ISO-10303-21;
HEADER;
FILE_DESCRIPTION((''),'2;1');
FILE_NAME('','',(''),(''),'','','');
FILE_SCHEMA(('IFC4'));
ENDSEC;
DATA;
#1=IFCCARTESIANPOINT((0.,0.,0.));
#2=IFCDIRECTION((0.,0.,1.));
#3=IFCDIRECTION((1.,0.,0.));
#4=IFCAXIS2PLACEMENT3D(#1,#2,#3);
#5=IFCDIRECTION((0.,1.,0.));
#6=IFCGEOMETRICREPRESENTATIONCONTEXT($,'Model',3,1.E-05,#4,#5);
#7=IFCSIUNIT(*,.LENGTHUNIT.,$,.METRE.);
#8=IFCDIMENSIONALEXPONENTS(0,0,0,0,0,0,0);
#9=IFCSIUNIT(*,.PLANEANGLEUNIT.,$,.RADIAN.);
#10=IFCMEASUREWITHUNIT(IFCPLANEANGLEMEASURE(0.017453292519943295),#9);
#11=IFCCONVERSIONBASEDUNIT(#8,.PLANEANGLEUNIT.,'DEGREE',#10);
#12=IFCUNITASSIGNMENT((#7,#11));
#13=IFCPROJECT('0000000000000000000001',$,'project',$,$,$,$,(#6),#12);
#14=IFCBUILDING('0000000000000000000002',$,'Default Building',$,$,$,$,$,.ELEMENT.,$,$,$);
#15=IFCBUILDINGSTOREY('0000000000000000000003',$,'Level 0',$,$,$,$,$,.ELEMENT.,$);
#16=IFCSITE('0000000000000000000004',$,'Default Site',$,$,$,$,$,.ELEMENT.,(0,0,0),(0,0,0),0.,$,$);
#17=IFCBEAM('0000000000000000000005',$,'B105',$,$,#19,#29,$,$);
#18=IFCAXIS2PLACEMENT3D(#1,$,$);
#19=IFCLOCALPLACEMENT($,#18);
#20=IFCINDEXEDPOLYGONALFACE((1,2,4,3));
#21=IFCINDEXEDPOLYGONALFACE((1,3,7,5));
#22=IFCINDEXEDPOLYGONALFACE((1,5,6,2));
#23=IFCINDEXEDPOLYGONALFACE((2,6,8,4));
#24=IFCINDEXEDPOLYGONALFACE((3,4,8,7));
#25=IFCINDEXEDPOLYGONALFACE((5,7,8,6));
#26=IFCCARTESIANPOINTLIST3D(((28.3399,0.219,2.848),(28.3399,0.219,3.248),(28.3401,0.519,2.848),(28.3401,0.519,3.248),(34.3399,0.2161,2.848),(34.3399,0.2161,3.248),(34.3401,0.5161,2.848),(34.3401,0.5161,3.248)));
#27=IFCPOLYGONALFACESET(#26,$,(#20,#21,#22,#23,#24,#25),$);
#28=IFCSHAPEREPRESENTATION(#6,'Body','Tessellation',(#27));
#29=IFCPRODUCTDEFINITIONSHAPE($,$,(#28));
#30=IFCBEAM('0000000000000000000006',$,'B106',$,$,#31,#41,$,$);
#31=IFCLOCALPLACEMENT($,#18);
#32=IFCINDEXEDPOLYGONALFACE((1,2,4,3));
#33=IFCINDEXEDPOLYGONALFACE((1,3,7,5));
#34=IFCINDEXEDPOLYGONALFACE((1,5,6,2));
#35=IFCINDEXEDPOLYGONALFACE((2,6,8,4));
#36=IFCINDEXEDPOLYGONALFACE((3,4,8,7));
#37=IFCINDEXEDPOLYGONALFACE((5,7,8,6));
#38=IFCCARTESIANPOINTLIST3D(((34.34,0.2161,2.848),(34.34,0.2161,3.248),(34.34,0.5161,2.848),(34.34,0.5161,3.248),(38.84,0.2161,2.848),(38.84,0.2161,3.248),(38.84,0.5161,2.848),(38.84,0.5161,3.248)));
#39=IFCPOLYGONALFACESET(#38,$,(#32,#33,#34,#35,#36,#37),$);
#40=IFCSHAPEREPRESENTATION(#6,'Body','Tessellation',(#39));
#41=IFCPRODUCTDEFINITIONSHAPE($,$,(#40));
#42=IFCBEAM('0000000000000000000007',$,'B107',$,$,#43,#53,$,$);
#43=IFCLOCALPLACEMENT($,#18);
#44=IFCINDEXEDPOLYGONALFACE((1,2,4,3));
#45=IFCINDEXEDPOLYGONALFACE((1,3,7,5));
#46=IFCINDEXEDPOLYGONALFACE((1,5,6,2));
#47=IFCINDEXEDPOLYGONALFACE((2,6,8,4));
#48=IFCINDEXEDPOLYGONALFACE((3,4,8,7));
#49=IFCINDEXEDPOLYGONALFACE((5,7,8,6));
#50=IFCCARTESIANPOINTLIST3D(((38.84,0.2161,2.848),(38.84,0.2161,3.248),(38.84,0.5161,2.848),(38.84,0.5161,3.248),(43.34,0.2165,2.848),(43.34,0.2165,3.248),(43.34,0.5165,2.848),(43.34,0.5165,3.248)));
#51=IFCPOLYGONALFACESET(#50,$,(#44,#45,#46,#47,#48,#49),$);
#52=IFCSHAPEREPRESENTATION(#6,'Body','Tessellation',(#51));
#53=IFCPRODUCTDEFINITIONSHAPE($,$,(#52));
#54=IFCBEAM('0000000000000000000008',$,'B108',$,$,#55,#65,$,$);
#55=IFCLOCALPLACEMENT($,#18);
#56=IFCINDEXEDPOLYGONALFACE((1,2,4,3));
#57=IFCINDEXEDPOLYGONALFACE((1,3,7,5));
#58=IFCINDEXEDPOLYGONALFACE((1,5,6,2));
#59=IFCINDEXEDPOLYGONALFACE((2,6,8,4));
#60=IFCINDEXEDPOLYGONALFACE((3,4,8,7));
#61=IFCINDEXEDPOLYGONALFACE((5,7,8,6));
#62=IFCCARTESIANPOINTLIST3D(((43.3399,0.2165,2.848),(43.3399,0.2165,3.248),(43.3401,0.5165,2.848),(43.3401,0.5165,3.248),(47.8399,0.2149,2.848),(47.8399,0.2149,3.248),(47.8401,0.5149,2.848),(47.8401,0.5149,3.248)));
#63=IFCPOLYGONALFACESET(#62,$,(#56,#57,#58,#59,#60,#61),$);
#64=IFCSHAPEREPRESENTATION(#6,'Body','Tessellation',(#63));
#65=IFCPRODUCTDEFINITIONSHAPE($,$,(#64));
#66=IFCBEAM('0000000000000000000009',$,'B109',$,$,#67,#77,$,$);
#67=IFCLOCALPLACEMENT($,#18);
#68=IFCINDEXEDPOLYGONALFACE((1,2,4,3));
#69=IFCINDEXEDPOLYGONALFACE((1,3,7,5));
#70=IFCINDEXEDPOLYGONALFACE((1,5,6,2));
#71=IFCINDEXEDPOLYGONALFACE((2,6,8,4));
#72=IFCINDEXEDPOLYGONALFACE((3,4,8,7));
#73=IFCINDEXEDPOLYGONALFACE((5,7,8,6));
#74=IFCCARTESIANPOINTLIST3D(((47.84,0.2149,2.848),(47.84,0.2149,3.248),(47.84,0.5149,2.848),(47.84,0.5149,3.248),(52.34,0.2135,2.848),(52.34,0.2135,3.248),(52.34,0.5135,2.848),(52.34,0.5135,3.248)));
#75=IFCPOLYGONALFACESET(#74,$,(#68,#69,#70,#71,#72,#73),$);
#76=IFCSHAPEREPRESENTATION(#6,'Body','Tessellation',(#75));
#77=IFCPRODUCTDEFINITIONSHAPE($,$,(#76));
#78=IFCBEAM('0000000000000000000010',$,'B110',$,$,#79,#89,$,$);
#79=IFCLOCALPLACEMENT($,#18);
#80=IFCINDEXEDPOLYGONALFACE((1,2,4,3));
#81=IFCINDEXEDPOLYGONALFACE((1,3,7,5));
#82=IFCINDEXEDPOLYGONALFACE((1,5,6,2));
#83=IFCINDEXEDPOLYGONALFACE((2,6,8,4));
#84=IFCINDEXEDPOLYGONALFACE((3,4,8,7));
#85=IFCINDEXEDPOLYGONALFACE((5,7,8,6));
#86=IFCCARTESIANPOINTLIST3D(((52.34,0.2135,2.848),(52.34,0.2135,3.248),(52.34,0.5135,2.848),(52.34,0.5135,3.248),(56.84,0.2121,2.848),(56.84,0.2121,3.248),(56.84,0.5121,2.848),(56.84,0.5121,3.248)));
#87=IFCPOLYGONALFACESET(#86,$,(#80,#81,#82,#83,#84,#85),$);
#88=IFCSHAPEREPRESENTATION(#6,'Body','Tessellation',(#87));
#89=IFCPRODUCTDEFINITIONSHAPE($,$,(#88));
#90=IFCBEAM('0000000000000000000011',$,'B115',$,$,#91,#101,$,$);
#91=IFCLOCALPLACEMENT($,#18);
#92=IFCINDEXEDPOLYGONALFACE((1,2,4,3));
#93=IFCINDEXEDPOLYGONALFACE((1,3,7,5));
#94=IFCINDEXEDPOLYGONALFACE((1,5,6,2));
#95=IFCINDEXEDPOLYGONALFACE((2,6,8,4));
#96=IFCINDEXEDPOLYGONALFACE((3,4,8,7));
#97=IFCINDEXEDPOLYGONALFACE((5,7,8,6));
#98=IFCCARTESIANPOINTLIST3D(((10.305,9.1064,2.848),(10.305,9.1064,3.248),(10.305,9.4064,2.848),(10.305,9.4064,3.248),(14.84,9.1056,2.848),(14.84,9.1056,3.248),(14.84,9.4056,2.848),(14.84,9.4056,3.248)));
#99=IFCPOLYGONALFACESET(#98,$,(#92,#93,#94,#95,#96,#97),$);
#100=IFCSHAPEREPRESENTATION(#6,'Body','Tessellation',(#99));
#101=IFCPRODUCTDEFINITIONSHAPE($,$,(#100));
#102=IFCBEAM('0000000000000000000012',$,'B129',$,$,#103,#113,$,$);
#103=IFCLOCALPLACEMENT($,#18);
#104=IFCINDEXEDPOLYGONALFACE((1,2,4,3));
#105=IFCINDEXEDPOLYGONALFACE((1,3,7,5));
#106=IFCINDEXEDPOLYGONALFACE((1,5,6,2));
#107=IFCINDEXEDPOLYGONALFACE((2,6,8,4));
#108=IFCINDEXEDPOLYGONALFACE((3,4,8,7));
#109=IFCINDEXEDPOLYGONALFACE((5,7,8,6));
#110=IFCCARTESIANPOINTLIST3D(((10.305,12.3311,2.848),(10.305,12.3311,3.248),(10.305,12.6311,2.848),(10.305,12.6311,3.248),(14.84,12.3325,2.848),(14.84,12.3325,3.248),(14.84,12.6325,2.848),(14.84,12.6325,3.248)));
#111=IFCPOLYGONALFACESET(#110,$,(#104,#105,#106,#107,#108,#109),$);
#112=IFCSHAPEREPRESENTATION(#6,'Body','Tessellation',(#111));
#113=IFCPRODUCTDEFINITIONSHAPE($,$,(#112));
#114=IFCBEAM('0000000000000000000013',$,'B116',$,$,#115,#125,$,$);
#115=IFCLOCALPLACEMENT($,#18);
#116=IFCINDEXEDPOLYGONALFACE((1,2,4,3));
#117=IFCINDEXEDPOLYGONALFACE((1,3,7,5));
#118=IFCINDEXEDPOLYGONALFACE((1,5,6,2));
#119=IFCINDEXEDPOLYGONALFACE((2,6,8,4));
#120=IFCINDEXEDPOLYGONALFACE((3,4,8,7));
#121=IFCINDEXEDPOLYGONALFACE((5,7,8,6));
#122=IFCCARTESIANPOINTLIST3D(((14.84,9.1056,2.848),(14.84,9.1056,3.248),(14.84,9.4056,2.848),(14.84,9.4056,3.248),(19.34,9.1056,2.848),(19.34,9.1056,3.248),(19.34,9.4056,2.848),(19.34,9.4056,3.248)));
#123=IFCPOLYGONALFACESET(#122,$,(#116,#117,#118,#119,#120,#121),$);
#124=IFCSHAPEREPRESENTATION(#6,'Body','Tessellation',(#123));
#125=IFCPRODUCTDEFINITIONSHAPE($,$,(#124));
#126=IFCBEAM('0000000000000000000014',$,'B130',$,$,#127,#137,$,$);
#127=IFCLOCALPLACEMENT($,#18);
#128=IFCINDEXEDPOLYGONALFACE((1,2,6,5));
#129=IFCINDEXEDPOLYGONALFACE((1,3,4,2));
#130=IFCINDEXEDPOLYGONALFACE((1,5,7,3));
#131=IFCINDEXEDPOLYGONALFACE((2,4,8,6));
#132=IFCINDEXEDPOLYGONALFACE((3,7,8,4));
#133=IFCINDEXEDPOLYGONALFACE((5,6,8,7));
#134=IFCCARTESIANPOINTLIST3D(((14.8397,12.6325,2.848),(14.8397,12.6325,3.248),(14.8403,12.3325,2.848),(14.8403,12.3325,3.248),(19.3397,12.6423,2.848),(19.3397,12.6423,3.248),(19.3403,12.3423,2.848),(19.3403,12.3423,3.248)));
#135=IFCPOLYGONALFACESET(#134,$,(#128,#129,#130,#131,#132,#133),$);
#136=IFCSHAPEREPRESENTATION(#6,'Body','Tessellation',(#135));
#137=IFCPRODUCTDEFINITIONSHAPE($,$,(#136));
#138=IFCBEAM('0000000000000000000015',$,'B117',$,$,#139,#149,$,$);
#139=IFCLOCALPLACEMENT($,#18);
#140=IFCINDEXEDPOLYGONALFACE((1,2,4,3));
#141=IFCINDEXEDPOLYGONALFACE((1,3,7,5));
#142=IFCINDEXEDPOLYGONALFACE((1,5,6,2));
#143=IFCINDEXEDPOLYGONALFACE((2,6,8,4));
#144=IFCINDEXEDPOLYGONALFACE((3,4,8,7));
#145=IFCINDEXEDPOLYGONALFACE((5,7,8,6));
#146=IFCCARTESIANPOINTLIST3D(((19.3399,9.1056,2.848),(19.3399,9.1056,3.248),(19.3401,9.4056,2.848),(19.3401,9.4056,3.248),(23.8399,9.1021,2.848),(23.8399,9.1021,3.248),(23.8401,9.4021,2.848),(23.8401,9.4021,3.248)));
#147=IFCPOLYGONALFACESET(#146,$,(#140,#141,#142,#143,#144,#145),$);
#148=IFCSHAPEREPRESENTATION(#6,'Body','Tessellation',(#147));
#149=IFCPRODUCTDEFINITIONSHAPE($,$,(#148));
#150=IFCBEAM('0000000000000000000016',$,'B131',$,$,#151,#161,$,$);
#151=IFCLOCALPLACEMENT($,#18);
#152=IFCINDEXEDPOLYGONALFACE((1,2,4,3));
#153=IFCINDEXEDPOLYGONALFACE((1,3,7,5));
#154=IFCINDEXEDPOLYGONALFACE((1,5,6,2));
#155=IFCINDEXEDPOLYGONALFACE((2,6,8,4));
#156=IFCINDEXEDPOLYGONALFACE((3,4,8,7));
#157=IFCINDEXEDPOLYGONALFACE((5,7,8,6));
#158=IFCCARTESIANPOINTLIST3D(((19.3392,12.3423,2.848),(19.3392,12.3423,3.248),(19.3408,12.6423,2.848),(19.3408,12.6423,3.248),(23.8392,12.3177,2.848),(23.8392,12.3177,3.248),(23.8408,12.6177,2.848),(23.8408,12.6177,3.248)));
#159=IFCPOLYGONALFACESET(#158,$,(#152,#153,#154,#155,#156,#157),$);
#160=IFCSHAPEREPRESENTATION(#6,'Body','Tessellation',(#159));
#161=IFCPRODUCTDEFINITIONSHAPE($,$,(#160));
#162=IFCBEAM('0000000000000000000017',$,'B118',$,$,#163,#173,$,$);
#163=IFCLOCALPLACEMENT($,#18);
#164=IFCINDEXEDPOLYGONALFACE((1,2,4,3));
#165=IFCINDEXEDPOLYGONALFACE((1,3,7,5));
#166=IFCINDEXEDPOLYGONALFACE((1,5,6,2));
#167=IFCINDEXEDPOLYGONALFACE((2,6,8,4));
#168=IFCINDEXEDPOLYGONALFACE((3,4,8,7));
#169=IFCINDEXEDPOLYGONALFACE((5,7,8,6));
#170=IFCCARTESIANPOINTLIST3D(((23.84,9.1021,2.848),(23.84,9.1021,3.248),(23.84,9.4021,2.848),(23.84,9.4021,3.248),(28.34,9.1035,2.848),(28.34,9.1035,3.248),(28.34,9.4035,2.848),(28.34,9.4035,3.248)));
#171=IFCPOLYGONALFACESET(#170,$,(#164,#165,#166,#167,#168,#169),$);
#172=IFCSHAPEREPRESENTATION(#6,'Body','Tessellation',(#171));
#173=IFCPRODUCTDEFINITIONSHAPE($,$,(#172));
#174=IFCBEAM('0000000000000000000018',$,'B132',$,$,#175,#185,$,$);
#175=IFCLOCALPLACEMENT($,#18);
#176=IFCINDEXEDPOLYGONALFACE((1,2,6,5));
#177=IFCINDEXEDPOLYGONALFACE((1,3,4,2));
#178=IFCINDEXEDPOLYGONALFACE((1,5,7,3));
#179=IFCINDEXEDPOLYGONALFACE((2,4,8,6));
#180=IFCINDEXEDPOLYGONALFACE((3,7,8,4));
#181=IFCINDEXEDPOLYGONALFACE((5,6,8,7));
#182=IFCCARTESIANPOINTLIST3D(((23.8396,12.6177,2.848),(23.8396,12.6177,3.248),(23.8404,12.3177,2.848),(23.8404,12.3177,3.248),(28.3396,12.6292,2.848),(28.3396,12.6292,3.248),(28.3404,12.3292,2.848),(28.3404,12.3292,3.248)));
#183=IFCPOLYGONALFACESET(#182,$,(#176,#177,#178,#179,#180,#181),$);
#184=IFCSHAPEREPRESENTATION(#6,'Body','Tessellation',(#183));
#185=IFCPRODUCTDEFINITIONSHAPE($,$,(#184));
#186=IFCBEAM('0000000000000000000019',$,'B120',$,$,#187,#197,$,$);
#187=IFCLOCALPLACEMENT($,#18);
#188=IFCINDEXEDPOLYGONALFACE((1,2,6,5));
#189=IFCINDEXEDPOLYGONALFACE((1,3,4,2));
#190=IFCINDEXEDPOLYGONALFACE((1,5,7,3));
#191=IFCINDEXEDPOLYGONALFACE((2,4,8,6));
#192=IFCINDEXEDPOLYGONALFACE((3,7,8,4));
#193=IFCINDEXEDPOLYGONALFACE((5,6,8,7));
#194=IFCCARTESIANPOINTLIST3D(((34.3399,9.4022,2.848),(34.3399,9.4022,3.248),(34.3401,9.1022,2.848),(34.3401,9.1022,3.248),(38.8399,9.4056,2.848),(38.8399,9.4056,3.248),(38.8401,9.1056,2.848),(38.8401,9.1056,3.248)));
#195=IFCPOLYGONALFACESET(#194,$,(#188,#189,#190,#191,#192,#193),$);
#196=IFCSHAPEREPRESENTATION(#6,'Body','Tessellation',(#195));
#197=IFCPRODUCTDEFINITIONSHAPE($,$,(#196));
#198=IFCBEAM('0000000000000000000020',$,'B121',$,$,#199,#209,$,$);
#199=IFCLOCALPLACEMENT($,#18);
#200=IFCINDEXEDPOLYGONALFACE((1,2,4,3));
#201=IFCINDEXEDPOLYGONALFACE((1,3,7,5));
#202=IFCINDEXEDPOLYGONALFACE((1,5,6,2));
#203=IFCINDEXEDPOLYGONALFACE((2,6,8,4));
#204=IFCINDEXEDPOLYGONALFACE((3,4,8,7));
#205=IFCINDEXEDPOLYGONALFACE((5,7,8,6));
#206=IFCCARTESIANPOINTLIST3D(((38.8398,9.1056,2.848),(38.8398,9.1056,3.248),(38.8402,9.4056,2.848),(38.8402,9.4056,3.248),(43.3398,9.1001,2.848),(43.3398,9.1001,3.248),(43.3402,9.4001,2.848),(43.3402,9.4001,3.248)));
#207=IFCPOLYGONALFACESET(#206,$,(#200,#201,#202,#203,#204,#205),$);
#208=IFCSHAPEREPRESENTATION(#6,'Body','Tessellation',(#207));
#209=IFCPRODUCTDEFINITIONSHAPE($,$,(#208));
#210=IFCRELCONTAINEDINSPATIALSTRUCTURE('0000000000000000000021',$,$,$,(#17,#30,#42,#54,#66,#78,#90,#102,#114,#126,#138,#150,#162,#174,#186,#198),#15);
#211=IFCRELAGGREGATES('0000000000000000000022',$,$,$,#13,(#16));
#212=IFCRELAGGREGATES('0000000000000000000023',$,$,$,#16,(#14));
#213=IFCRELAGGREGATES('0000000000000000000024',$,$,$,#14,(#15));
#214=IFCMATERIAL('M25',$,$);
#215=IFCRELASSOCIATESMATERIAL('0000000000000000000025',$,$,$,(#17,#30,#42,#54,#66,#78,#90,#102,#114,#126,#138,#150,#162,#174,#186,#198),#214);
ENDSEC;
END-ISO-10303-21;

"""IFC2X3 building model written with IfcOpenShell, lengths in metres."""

from ifc_helpers import new_model, entity, si_unit, converted_unit, direction, frame, frame_2d, origin_with_axes, place, context, project, spatial, rectangle, extrude, material, element, save


model = new_model("IFC2X3")

# Units and contexts
model_context = context("Model", 3, precision=1e-05, world=origin_with_axes(), true_north=direction((0.0, 1.0, 0.0)))
ifc_project = project(units=[si_unit("LENGTHUNIT", "METRE"), converted_unit("PLANEANGLEUNIT", "DEGREE", entity("IfcPlaneAngleMeasure", 0.017453292519943295), si_unit("PLANEANGLEUNIT", "RADIAN"), dimensions=[0, 0, 0, 0, 0, 0, 0])], contexts=[model_context])

# Site, building, storey
site = spatial("IfcSite", under=ifc_project, Name="Default Site", CompositionType="ELEMENT", RefLatitude=(0, 0, 0), RefLongitude=(0, 0, 0), RefElevation=0.0)
building = spatial("IfcBuilding", under=site, Name="Default Building", CompositionType="ELEMENT")
storey = spatial("IfcBuildingStorey", under=building, Name="Level 0", CompositionType="ELEMENT")

# Beams
ifc_material = material(Name="M25")
placement = place(None, origin_with_axes())
element("IfcBeam", 1, at=placement, inside=storey, material=ifc_material, Name="B105", context=model_context, shape_type="SweptSolid", body=[
    extrude(rectangle(XDim=0.3, YDim=0.4, at=frame_2d((0.0, 0.0), x_axis=(0.0, 1.0, 0.0))), frame((28.34, 0.369, 3.048), z_axis=(1.0, -0.000487, 0.0), x_axis=(0.0, 0.0, -1.0)), (0.0, 0.0, 1.0), 6.0),
])
element("IfcBeam", 2, at=placement, inside=storey, material=ifc_material, Name="B106", context=model_context, shape_type="SweptSolid", body=[
    extrude(rectangle(XDim=0.3, YDim=0.4, at=frame_2d((0.0, 0.0), x_axis=(0.0, 1.0, 0.0))), frame((34.34, 0.3661, 3.048), z_axis=(1.0, 0.000003, 0.0), x_axis=(0.0, 0.0, -1.0)), (0.0, 0.0, 1.0), 4.5),
])
element("IfcBeam", 3, at=placement, inside=storey, material=ifc_material, Name="B107", context=model_context, shape_type="SweptSolid", body=[
    extrude(rectangle(XDim=0.3, YDim=0.4, at=frame_2d((0.0, 0.0), x_axis=(0.0, 1.0, 0.0))), frame((38.84, 0.3661, 3.048), z_axis=(1.0, 0.000077, 0.0), x_axis=(0.0, 0.0, -1.0)), (0.0, 0.0, 1.0), 4.5),
])
element("IfcBeam", 4, at=placement, inside=storey, material=ifc_material, Name="B108", context=model_context, shape_type="SweptSolid", body=[
    extrude(rectangle(XDim=0.3, YDim=0.4, at=frame_2d((0.0, 0.0), x_axis=(0.0, 1.0, 0.0))), frame((43.34, 0.3665, 3.048), z_axis=(1.0, -0.000358, 0.0), x_axis=(0.0, 0.0, -1.0)), (0.0, 0.0, 1.0), 4.5),
])
element("IfcBeam", 5, at=placement, inside=storey, material=ifc_material, Name="B109", context=model_context, shape_type="SweptSolid", body=[
    extrude(rectangle(XDim=0.3, YDim=0.4, at=frame_2d((0.0, 0.0), x_axis=(0.0, 1.0, 0.0))), frame((47.84, 0.3649, 3.048), z_axis=(1.0, -0.000297, 0.0), x_axis=(0.0, 0.0, -1.0)), (0.0, 0.0, 1.0), 4.5),
])
element("IfcBeam", 6, at=placement, inside=storey, material=ifc_material, Name="B110", context=model_context, shape_type="SweptSolid", body=[
    extrude(rectangle(XDim=0.3, YDim=0.4, at=frame_2d((0.0, 0.0), x_axis=(0.0, 1.0, 0.0))), frame((52.34, 0.3635, 3.048), z_axis=(1.0, -0.000311, 0.0), x_axis=(0.0, 0.0, -1.0)), (0.0, 0.0, 1.0), 4.5),
])
element("IfcBeam", 7, at=placement, inside=storey, material=ifc_material, Name="B115", context=model_context, shape_type="SweptSolid", body=[
    extrude(rectangle(XDim=0.3, YDim=0.4, at=frame_2d((0.0, 0.0), x_axis=(0.0, 1.0, 0.0))), frame((10.305, 9.2564, 3.048), z_axis=(1.0, -0.000182, 0.0), x_axis=(0.0, 0.0, -1.0)), (0.0, 0.0, 1.0), 4.535),
])
element("IfcBeam", 8, at=placement, inside=storey, material=ifc_material, Name="B129", context=model_context, shape_type="SweptSolid", body=[
    extrude(rectangle(XDim=0.3, YDim=0.4, at=frame_2d((0.0, 0.0), x_axis=(0.0, 1.0, 0.0))), frame((10.305, 12.4811, 3.048), z_axis=(1.0, 0.000301, 0.0), x_axis=(0.0, 0.0, -1.0)), (0.0, 0.0, 1.0), 4.535),
])
element("IfcBeam", 9, at=placement, inside=storey, material=ifc_material, Name="B116", context=model_context, shape_type="SweptSolid", body=[
    extrude(rectangle(XDim=0.3, YDim=0.4, at=frame_2d((0.0, 0.0), x_axis=(0.0, 1.0, 0.0))), frame((14.84, 9.2556, 3.048), z_axis=(1.0, 0.000013, 0.0), x_axis=(0.0, 0.0, -1.0)), (0.0, 0.0, 1.0), 4.5),
])
element("IfcBeam", 10, at=placement, inside=storey, material=ifc_material, Name="B130", context=model_context, shape_type="SweptSolid", body=[
    extrude(rectangle(XDim=0.3, YDim=0.4, at=frame_2d((0.0, 0.0), x_axis=(0.0, 1.0, 0.0))), frame((14.84, 12.4825, 3.048), z_axis=(0.999998, 0.002176, 0.0), x_axis=(0.0, 0.0, -1.0)), (0.0, 0.0, 1.0), 4.5),
])
element("IfcBeam", 11, at=placement, inside=storey, material=ifc_material, Name="B117", context=model_context, shape_type="SweptSolid", body=[
    extrude(rectangle(XDim=0.3, YDim=0.4, at=frame_2d((0.0, 0.0), x_axis=(0.0, 1.0, 0.0))), frame((19.34, 9.2556, 3.048), z_axis=(1.0, -0.000779, 0.0), x_axis=(0.0, 0.0, -1.0)), (0.0, 0.0, 1.0), 4.5),
])
element("IfcBeam", 12, at=placement, inside=storey, material=ifc_material, Name="B131", context=model_context, shape_type="SweptSolid", body=[
    extrude(rectangle(XDim=0.3, YDim=0.4, at=frame_2d((0.0, 0.0), x_axis=(0.0, 1.0, 0.0))), frame((19.34, 12.4923, 3.048), z_axis=(0.999985, -0.005463, 0.0), x_axis=(0.0, 0.0, -1.0)), (0.0, 0.0, 1.0), 4.5001),
])
element("IfcBeam", 13, at=placement, inside=storey, material=ifc_material, Name="B118", context=model_context, shape_type="SweptSolid", body=[
    extrude(rectangle(XDim=0.3, YDim=0.4, at=frame_2d((0.0, 0.0), x_axis=(0.0, 1.0, 0.0))), frame((23.84, 9.2521, 3.048), z_axis=(1.0, 0.000307, 0.0), x_axis=(0.0, 0.0, -1.0)), (0.0, 0.0, 1.0), 4.5),
])
element("IfcBeam", 14, at=placement, inside=storey, material=ifc_material, Name="B132", context=model_context, shape_type="SweptSolid", body=[
    extrude(rectangle(XDim=0.3, YDim=0.4, at=frame_2d((0.0, 0.0), x_axis=(0.0, 1.0, 0.0))), frame((23.84, 12.4677, 3.048), z_axis=(0.999997, 0.002551, 0.0), x_axis=(0.0, 0.0, -1.0)), (0.0, 0.0, 1.0), 4.5),
])
element("IfcBeam", 15, at=placement, inside=storey, material=ifc_material, Name="B120", context=model_context, shape_type="SweptSolid", body=[
    extrude(rectangle(XDim=0.3, YDim=0.4, at=frame_2d((0.0, 0.0), x_axis=(0.0, 1.0, 0.0))), frame((34.34, 9.2522, 3.048), z_axis=(1.0, 0.000748, 0.0), x_axis=(0.0, 0.0, -1.0)), (0.0, 0.0, 1.0), 4.5),
])
element("IfcBeam", 16, at=placement, inside=storey, material=ifc_material, Name="B121", context=model_context, shape_type="SweptSolid", body=[
    extrude(rectangle(XDim=0.3, YDim=0.4, at=frame_2d((0.0, 0.0), x_axis=(0.0, 1.0, 0.0))), frame((38.84, 9.2556, 3.048), z_axis=(0.999999, -0.001227, 0.0), x_axis=(0.0, 0.0, -1.0)), (0.0, 0.0, 1.0), 4.5),
])

save(model, "model.ifc")
